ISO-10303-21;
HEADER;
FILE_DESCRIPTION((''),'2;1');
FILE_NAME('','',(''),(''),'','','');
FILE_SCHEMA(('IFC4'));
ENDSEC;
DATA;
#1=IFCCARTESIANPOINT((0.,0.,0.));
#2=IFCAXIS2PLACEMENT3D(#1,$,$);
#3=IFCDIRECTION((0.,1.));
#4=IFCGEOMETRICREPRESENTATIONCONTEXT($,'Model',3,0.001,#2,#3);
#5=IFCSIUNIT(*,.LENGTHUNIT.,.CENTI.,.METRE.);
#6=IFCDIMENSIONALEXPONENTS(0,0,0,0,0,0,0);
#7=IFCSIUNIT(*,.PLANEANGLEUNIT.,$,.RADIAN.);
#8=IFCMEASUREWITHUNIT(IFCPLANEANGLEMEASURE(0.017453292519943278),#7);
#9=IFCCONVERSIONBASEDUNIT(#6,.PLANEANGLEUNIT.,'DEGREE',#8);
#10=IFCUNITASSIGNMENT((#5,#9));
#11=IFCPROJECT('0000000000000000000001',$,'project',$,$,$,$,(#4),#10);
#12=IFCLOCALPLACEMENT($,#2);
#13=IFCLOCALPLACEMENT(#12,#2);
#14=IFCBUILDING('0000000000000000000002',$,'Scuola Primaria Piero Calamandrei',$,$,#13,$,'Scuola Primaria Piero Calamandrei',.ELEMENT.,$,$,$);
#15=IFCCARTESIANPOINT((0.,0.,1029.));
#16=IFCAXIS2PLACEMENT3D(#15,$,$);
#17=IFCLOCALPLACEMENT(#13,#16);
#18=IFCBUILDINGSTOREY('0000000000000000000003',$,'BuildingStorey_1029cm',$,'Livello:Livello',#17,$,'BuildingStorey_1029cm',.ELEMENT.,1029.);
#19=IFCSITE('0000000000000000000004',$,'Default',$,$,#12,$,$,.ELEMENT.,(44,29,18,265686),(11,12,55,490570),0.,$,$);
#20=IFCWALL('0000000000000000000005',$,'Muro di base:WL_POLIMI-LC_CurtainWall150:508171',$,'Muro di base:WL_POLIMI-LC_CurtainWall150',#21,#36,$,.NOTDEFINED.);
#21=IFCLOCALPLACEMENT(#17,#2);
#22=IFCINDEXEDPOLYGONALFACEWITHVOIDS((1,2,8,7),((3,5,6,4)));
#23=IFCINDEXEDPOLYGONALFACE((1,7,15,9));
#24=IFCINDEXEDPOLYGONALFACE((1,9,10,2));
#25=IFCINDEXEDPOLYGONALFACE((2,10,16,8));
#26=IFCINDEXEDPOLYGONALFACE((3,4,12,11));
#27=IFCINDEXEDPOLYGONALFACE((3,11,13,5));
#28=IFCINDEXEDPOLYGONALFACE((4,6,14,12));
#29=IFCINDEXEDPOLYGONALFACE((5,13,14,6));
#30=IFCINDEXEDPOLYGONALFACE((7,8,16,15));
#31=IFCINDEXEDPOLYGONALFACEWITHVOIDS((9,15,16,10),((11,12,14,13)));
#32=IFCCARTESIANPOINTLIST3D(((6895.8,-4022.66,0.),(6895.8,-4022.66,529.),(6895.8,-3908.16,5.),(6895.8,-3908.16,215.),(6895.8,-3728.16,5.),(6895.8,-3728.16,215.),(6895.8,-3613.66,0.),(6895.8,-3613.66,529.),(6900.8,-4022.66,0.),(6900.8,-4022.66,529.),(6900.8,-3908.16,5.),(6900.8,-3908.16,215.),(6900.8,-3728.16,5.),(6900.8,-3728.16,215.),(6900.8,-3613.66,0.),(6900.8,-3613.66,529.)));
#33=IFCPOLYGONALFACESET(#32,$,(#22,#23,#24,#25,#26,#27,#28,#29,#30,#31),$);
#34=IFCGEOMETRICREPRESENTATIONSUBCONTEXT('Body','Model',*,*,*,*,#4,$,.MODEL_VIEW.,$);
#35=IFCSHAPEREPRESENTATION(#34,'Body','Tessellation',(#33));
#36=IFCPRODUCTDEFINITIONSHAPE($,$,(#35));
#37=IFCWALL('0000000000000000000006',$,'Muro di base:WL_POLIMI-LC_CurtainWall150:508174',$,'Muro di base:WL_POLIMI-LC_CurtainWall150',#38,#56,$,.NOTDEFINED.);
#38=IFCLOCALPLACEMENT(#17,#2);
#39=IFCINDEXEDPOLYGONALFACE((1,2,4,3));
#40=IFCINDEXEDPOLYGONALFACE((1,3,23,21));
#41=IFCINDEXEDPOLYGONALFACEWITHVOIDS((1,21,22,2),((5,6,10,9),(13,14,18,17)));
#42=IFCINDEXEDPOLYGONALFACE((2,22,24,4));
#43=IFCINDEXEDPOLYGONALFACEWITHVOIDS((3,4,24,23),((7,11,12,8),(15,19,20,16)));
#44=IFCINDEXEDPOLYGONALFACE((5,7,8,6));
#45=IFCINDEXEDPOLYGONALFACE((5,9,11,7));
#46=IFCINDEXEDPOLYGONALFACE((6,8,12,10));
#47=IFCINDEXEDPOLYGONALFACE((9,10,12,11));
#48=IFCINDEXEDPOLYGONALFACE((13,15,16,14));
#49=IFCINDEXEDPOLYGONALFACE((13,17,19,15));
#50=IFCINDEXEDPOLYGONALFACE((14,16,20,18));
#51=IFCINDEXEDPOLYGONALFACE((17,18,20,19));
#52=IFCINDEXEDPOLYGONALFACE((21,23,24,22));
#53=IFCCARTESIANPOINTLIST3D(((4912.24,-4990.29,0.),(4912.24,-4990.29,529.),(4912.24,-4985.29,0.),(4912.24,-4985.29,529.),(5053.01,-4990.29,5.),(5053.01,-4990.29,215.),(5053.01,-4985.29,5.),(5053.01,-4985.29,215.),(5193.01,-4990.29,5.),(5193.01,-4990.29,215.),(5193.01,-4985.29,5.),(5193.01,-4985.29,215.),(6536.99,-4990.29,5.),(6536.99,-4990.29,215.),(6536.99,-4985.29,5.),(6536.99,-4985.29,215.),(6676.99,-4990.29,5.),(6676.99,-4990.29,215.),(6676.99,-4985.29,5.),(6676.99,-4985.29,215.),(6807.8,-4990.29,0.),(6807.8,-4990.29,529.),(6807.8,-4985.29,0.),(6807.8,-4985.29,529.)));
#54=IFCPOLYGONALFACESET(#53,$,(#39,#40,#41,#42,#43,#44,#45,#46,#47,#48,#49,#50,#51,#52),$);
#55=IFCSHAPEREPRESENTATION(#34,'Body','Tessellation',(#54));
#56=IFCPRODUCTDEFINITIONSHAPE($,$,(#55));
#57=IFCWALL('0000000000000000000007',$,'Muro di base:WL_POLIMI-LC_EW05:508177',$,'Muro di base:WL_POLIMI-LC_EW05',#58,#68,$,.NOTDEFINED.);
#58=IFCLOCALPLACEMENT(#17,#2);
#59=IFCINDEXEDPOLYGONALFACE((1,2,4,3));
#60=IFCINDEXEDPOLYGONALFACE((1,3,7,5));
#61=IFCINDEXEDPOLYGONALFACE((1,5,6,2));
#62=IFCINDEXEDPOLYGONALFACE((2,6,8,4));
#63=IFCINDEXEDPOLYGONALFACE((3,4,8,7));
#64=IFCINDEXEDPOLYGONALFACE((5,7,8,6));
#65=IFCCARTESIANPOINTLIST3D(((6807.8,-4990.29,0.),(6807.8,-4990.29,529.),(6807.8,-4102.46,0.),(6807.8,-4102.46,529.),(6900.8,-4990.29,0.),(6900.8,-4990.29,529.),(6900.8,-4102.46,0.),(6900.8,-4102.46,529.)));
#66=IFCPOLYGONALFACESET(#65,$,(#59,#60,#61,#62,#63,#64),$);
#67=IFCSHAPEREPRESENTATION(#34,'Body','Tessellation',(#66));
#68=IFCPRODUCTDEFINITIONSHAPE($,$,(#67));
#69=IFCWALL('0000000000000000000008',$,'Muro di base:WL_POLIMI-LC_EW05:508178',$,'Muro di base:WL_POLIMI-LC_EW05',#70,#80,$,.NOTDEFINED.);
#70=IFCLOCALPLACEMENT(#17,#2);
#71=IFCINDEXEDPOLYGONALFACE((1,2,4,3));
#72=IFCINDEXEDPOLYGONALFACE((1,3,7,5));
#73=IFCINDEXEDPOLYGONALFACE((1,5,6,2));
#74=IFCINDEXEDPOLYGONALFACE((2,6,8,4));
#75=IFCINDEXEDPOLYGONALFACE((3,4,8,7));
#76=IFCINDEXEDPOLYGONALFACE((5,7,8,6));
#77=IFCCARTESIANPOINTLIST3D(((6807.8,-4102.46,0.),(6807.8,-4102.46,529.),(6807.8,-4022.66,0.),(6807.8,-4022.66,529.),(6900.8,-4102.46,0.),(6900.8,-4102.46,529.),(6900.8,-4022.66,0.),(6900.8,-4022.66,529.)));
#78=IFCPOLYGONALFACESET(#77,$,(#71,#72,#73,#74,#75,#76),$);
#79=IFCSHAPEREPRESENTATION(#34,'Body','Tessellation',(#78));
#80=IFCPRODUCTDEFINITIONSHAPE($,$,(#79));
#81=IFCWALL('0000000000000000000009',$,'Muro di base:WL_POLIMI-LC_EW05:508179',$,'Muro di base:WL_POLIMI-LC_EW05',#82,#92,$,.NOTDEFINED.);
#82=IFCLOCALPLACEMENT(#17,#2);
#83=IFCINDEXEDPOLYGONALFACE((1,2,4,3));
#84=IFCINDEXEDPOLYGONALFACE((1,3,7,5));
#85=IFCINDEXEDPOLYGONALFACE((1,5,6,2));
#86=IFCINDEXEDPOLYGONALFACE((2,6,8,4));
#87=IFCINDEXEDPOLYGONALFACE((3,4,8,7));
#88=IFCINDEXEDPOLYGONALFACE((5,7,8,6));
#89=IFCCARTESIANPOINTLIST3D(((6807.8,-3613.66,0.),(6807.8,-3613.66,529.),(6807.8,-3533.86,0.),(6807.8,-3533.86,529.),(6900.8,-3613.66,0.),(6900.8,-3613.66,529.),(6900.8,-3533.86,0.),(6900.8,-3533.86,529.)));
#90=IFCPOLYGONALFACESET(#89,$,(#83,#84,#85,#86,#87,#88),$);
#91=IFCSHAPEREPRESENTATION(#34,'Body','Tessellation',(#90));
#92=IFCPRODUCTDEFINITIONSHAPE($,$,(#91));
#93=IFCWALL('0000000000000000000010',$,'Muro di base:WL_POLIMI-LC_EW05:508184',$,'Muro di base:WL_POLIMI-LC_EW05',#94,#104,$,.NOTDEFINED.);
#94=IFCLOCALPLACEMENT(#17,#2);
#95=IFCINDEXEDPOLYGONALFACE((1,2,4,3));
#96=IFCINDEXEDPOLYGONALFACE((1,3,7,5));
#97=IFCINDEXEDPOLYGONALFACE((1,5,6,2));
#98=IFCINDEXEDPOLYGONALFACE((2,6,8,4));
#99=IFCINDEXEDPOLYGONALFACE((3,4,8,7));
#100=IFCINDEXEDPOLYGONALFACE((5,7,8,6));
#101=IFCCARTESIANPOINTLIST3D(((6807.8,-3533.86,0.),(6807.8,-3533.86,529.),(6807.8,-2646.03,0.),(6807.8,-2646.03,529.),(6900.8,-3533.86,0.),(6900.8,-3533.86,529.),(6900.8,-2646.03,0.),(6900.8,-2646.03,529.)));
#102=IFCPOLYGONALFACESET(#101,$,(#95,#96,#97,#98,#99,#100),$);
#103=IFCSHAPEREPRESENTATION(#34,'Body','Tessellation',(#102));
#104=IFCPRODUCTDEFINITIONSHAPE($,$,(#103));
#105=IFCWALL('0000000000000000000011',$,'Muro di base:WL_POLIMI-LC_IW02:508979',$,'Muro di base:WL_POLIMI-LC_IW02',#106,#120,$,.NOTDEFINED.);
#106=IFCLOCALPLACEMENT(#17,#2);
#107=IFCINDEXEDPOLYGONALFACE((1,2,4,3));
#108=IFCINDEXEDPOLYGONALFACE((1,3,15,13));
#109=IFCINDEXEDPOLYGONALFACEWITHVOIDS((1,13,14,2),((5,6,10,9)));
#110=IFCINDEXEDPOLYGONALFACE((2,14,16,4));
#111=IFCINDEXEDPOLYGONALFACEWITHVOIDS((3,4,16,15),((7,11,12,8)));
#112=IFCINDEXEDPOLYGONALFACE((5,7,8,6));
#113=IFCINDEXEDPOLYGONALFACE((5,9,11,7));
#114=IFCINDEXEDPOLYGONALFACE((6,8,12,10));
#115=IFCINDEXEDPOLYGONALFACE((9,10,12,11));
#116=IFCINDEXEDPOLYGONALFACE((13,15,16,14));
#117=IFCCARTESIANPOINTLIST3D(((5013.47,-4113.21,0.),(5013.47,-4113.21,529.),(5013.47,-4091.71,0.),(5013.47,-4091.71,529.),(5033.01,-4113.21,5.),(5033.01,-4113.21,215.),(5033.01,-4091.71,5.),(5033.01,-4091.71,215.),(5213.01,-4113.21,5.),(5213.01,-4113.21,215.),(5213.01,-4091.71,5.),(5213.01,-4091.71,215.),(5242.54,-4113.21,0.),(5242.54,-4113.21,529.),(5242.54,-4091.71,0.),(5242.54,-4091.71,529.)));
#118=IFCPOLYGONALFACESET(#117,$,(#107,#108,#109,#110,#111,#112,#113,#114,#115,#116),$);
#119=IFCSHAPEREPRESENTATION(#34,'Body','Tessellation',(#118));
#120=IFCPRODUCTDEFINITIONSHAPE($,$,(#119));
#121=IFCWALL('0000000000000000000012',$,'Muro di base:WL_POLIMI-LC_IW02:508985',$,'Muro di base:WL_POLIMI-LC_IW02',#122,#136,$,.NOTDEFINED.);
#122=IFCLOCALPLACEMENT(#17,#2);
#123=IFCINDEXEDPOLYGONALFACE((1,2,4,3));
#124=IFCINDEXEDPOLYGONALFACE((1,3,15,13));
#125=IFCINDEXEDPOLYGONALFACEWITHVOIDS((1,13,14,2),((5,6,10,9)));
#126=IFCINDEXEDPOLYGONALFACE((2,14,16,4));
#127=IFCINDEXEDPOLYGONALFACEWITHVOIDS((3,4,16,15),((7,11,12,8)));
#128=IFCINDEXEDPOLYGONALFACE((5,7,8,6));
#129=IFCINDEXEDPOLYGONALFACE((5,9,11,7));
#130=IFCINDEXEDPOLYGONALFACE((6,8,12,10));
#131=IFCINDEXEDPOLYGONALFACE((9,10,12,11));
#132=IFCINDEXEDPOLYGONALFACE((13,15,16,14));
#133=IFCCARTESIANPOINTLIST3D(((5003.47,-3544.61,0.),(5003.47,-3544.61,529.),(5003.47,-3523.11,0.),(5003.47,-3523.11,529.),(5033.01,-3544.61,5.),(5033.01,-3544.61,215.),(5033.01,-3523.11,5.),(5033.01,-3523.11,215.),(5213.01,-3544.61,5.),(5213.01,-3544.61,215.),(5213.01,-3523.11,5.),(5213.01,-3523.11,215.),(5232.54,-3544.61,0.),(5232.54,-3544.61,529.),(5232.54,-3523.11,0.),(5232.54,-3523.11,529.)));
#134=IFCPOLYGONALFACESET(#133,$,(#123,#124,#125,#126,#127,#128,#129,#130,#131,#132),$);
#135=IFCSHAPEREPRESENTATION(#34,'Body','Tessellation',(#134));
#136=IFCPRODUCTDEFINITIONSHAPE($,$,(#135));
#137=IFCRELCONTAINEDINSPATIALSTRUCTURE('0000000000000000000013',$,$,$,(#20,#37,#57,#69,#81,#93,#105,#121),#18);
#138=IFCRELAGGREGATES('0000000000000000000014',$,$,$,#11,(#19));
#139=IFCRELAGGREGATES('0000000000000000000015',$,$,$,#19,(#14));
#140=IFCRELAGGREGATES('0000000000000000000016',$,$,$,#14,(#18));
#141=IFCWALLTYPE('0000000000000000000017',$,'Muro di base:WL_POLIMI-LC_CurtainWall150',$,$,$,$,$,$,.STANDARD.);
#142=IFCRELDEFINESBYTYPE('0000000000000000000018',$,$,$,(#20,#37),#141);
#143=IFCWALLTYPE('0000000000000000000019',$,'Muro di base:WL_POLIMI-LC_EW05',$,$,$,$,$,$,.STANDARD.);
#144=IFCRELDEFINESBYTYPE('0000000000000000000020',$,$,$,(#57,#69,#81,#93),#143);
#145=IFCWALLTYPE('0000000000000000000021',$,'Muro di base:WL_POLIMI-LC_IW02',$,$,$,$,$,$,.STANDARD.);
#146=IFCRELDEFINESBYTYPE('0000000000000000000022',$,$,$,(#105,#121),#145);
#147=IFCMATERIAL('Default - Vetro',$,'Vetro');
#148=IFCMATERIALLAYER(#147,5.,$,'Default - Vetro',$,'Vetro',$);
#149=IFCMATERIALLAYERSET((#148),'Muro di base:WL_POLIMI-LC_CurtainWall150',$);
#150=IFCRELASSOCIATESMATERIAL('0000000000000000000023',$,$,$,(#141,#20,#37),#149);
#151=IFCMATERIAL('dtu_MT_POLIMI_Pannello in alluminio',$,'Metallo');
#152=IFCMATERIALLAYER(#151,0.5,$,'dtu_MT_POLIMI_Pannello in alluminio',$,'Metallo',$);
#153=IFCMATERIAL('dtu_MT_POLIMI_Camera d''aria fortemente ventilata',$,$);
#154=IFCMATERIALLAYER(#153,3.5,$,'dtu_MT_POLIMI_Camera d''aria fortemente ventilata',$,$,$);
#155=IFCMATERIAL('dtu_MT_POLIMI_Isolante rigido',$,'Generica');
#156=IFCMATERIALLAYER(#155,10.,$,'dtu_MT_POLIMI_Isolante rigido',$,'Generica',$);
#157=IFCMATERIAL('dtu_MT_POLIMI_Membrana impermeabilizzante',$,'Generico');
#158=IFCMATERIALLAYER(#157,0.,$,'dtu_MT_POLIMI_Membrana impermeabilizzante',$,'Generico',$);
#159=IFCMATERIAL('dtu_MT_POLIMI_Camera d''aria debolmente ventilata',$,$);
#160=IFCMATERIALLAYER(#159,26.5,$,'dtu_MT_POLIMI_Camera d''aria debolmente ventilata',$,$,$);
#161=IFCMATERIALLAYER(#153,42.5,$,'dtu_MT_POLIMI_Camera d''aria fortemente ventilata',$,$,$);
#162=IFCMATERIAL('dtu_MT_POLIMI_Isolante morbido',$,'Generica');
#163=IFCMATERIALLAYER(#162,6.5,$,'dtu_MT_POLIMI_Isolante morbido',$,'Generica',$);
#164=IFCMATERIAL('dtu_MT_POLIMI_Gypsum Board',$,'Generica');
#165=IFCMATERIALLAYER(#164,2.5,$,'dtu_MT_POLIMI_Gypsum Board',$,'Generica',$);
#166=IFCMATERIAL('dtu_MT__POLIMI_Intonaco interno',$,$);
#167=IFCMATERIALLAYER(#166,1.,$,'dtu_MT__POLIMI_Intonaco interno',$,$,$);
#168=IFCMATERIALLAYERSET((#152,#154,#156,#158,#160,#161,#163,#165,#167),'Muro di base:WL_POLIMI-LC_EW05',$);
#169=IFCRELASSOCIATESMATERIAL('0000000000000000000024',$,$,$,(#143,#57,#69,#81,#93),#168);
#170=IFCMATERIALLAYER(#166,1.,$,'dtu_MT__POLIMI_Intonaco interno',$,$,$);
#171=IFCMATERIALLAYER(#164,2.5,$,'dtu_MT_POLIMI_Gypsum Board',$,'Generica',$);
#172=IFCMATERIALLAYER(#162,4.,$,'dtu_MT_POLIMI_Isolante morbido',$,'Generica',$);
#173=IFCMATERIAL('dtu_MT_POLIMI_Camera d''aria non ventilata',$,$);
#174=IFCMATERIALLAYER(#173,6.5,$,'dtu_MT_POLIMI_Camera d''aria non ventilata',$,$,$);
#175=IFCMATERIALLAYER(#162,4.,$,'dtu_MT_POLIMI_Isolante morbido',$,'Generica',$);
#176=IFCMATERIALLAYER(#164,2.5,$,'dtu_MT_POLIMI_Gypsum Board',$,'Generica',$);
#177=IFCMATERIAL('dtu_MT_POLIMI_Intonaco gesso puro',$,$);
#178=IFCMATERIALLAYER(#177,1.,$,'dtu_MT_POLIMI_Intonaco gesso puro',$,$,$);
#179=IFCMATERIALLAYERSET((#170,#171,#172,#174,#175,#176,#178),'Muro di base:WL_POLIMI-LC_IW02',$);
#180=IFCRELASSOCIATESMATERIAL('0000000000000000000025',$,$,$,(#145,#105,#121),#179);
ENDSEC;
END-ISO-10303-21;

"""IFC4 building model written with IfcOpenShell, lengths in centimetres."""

from ifc_helpers import new_model, entity, si_unit, converted_unit, direction, frame, frame_2d, origin, place, context, subcontext, project, spatial, rectangle, extrude, material, layer, layer_set, layer_usage, type_object, element, save


model = new_model("IFC4")

# Units and contexts
model_context = context("Model", 3, precision=0.001, world=origin(), true_north=direction((0.0, 1.0)))
body_context = subcontext(model_context, "Body", "Model", "MODEL_VIEW")
ifc_project = project(units=[si_unit("LENGTHUNIT", "METRE", prefix="CENTI"), converted_unit("PLANEANGLEUNIT", "DEGREE", entity("IfcPlaneAngleMeasure", 0.017453292519943278), si_unit("PLANEANGLEUNIT", "RADIAN"), dimensions=[0, 0, 0, 0, 0, 0, 0])], contexts=[model_context])

# Site, building, storey
site_placement = place(None, origin())
site = spatial("IfcSite", under=ifc_project, at=site_placement, Name="Default", CompositionType="ELEMENT", RefLatitude=(44, 29, 18, 265686), RefLongitude=(11, 12, 55, 490570), RefElevation=0.0)
building_placement = place(site_placement, origin())
building = spatial("IfcBuilding", under=site, at=building_placement, Name="Scuola Primaria Piero Calamandrei", LongName="Scuola Primaria Piero Calamandrei", CompositionType="ELEMENT")
storey_placement = place(building_placement, frame((0.0, 0.0, 1029.0)))
storey = spatial("IfcBuildingStorey", under=building, at=storey_placement, Name="BuildingStorey_1029cm", ObjectType="Livello:Livello", LongName="BuildingStorey_1029cm", CompositionType="ELEMENT", Elevation=1029.0)

# Wall, opening
ifc_material_1 = material(Name="Default - Vetro", Category="Vetro")
ifc_layer_1 = layer(ifc_material_1, 5.0, Name="Default - Vetro", Category="Vetro")
ifc_layer_set_1 = layer_set([ifc_layer_1], Name="Muro di base:WL_POLIMI-LC_CurtainWall150")
ifc_layer_usage_1 = layer_usage(ifc_layer_set_1, "AXIS2", "NEGATIVE", 2.5)
wall_type_1 = type_object("IfcWallType", Name="Muro di base:WL_POLIMI-LC_CurtainWall150", PredefinedType="STANDARD", material=ifc_layer_set_1)
wall_1_placement = place(storey_placement, frame((6898.3, -3613.66, 0.0), z_axis=(0.0, 0.0, 1.0), x_axis=(0.0, -1.0, 0.0)))
wall_1 = element("IfcWall", 1, at=wall_1_placement, inside=storey, type_object=wall_type_1, material=ifc_layer_usage_1, Name="Muro di base:WL_POLIMI-LC_CurtainWall150:508171", ObjectType="Muro di base:WL_POLIMI-LC_CurtainWall150", PredefinedType="NOTDEFINED", context=body_context, shape_type="SweptSolid", body=[
    extrude(rectangle(XDim=409.0, YDim=5.0, at=frame_2d((204.5, 0.0), x_axis=(-1.0, 0.0))), origin(), (0.0, 0.0, 1.0), 529.0),
])
opening_1_placement = place(wall_1_placement, frame((114.5, -2.5, 5.0)))
element("IfcOpeningElement", 2, at=opening_1_placement, cuts=wall_1, PredefinedType="OPENING", context=body_context, shape_type="SweptSolid", body=[
    extrude(rectangle(XDim=210.0, YDim=180.0, at=frame_2d((105.0, 90.0), x_axis=(-1.0, 0.0))), frame((0.0, 0.0, 0.0), z_axis=(0.0, 1.0, 0.0), x_axis=(0.0, 0.0, 1.0)), (0.0, 0.0, 1.0), 5.0),
])

# Wall, openings
ifc_layer_usage_2 = layer_usage(ifc_layer_set_1, "AXIS2", "NEGATIVE", 2.5)
wall_2_placement = place(storey_placement, frame((6807.8, -4987.79, 0.0), z_axis=(0.0, 0.0, 1.0), x_axis=(-1.0, 0.0, 0.0)))
wall_2 = element("IfcWall", 3, at=wall_2_placement, inside=storey, type_object=wall_type_1, material=ifc_layer_usage_2, Name="Muro di base:WL_POLIMI-LC_CurtainWall150:508174", ObjectType="Muro di base:WL_POLIMI-LC_CurtainWall150", PredefinedType="NOTDEFINED", context=body_context, shape_type="SweptSolid", body=[
    extrude(rectangle(XDim=1895.56, YDim=5.0, at=frame_2d((947.78, 0.0), x_axis=(-1.0, 0.0))), origin(), (0.0, 0.0, 1.0), 529.0),
])
opening_2_placement = place(wall_2_placement, frame((1614.79, -2.5, 5.0)))
element("IfcOpeningElement", 4, at=opening_2_placement, cuts=wall_2, PredefinedType="OPENING", context=body_context, shape_type="SweptSolid", body=[
    extrude(rectangle(XDim=210.0, YDim=140.0, at=frame_2d((105.0, 70.0), x_axis=(-1.0, 0.0))), frame((0.0, 0.0, 0.0), z_axis=(0.0, 1.0, 0.0), x_axis=(0.0, 0.0, 1.0)), (0.0, 0.0, 1.0), 5.0),
])
opening_3_placement = place(wall_2_placement, frame((130.81, -2.5, 5.0)))
element("IfcOpeningElement", 5, at=opening_3_placement, cuts=wall_2, PredefinedType="OPENING", context=body_context, shape_type="SweptSolid", body=[
    extrude(rectangle(XDim=210.0, YDim=140.0, at=frame_2d((105.0, 70.0), x_axis=(-1.0, 0.0))), frame((0.0, 0.0, 0.0), z_axis=(0.0, 1.0, 0.0), x_axis=(0.0, 0.0, 1.0)), (0.0, 0.0, 1.0), 5.0),
])

# Walls
ifc_material_2 = material(Name="dtu_MT_POLIMI_Pannello in alluminio", Category="Metallo")
ifc_layer_2 = layer(ifc_material_2, 0.5, Name="dtu_MT_POLIMI_Pannello in alluminio", Category="Metallo")
ifc_material_3 = material(Name="dtu_MT_POLIMI_Camera d'aria fortemente ventilata")
ifc_layer_3 = layer(ifc_material_3, 3.5, Name="dtu_MT_POLIMI_Camera d'aria fortemente ventilata")
ifc_material_4 = material(Name="dtu_MT_POLIMI_Isolante rigido", Category="Generica")
ifc_layer_4 = layer(ifc_material_4, 10.0, Name="dtu_MT_POLIMI_Isolante rigido", Category="Generica")
ifc_material_5 = material(Name="dtu_MT_POLIMI_Membrana impermeabilizzante", Category="Generico")
ifc_layer_5 = layer(ifc_material_5, 0.0, Name="dtu_MT_POLIMI_Membrana impermeabilizzante", Category="Generico")
ifc_material_6 = material(Name="dtu_MT_POLIMI_Camera d'aria debolmente ventilata")
ifc_layer_6 = layer(ifc_material_6, 26.5, Name="dtu_MT_POLIMI_Camera d'aria debolmente ventilata")
ifc_layer_7 = layer(ifc_material_3, 42.5, Name="dtu_MT_POLIMI_Camera d'aria fortemente ventilata")
ifc_material_7 = material(Name="dtu_MT_POLIMI_Isolante morbido", Category="Generica")
ifc_layer_8 = layer(ifc_material_7, 6.5, Name="dtu_MT_POLIMI_Isolante morbido", Category="Generica")
ifc_material_8 = material(Name="dtu_MT_POLIMI_Gypsum Board", Category="Generica")
ifc_layer_9 = layer(ifc_material_8, 2.5, Name="dtu_MT_POLIMI_Gypsum Board", Category="Generica")
ifc_material_9 = material(Name="dtu_MT__POLIMI_Intonaco interno")
ifc_layer_10 = layer(ifc_material_9, 1.0, Name="dtu_MT__POLIMI_Intonaco interno")
ifc_layer_set_2 = layer_set([ifc_layer_2, ifc_layer_3, ifc_layer_4, ifc_layer_5, ifc_layer_6, ifc_layer_7, ifc_layer_8, ifc_layer_9, ifc_layer_10], Name="Muro di base:WL_POLIMI-LC_EW05")
ifc_layer_usage_3 = layer_usage(ifc_layer_set_2, "AXIS2", "NEGATIVE", 46.5)
wall_type_2 = type_object("IfcWallType", Name="Muro di base:WL_POLIMI-LC_EW05", PredefinedType="STANDARD", material=ifc_layer_set_2)
wall_3_placement = place(storey_placement, frame((6854.3, -4102.46, 0.0), z_axis=(0.0, 0.0, 1.0), x_axis=(0.0, -1.0, 0.0)))
element("IfcWall", 6, at=wall_3_placement, inside=storey, type_object=wall_type_2, material=ifc_layer_usage_3, Name="Muro di base:WL_POLIMI-LC_EW05:508177", ObjectType="Muro di base:WL_POLIMI-LC_EW05", PredefinedType="NOTDEFINED", context=body_context, shape_type="SweptSolid", body=[
    extrude(rectangle(XDim=887.82, YDim=93.0, at=frame_2d((443.91, 0.0), x_axis=(-1.0, 0.0))), origin(), (0.0, 0.0, 1.0), 529.0),
])
ifc_layer_usage_4 = layer_usage(ifc_layer_set_2, "AXIS2", "NEGATIVE", 46.5)
wall_4_placement = place(storey_placement, frame((6854.3, -4022.66, 0.0), z_axis=(0.0, 0.0, 1.0), x_axis=(0.0, -1.0, 0.0)))
element("IfcWall", 7, at=wall_4_placement, inside=storey, type_object=wall_type_2, material=ifc_layer_usage_4, Name="Muro di base:WL_POLIMI-LC_EW05:508178", ObjectType="Muro di base:WL_POLIMI-LC_EW05", PredefinedType="NOTDEFINED", context=body_context, shape_type="SweptSolid", body=[
    extrude(rectangle(XDim=79.8, YDim=93.0, at=frame_2d((39.9, 0.0), x_axis=(-1.0, 0.0))), origin(), (0.0, 0.0, 1.0), 529.0),
])
ifc_layer_usage_5 = layer_usage(ifc_layer_set_2, "AXIS2", "NEGATIVE", 46.5)
wall_5_placement = place(storey_placement, frame((6854.3, -3533.86, 0.0), z_axis=(0.0, 0.0, 1.0), x_axis=(0.0, -1.0, 0.0)))
element("IfcWall", 8, at=wall_5_placement, inside=storey, type_object=wall_type_2, material=ifc_layer_usage_5, Name="Muro di base:WL_POLIMI-LC_EW05:508179", ObjectType="Muro di base:WL_POLIMI-LC_EW05", PredefinedType="NOTDEFINED", context=body_context, shape_type="SweptSolid", body=[
    extrude(rectangle(XDim=79.8, YDim=93.0, at=frame_2d((39.9, 0.0), x_axis=(-1.0, 0.0))), origin(), (0.0, 0.0, 1.0), 529.0),
])
ifc_layer_usage_6 = layer_usage(ifc_layer_set_2, "AXIS2", "NEGATIVE", 46.5)
wall_6_placement = place(storey_placement, frame((6854.3, -2646.03, 0.0), z_axis=(0.0, 0.0, 1.0), x_axis=(0.0, -1.0, 0.0)))
element("IfcWall", 9, at=wall_6_placement, inside=storey, type_object=wall_type_2, material=ifc_layer_usage_6, Name="Muro di base:WL_POLIMI-LC_EW05:508184", ObjectType="Muro di base:WL_POLIMI-LC_EW05", PredefinedType="NOTDEFINED", context=body_context, shape_type="SweptSolid", body=[
    extrude(rectangle(XDim=887.82, YDim=93.0, at=frame_2d((443.91, 0.0), x_axis=(-1.0, 0.0))), origin(), (0.0, 0.0, 1.0), 529.0),
])

# Walls, openings
ifc_layer_11 = layer(ifc_material_9, 1.0, Name="dtu_MT__POLIMI_Intonaco interno")
ifc_layer_12 = layer(ifc_material_8, 2.5, Name="dtu_MT_POLIMI_Gypsum Board", Category="Generica")
ifc_layer_13 = layer(ifc_material_7, 4.0, Name="dtu_MT_POLIMI_Isolante morbido", Category="Generica")
ifc_material_10 = material(Name="dtu_MT_POLIMI_Camera d'aria non ventilata")
ifc_layer_14 = layer(ifc_material_10, 6.5, Name="dtu_MT_POLIMI_Camera d'aria non ventilata")
ifc_layer_15 = layer(ifc_material_7, 4.0, Name="dtu_MT_POLIMI_Isolante morbido", Category="Generica")
ifc_layer_16 = layer(ifc_material_8, 2.5, Name="dtu_MT_POLIMI_Gypsum Board", Category="Generica")
ifc_material_11 = material(Name="dtu_MT_POLIMI_Intonaco gesso puro")
ifc_layer_17 = layer(ifc_material_11, 1.0, Name="dtu_MT_POLIMI_Intonaco gesso puro")
ifc_layer_set_3 = layer_set([ifc_layer_11, ifc_layer_12, ifc_layer_13, ifc_layer_14, ifc_layer_15, ifc_layer_16, ifc_layer_17], Name="Muro di base:WL_POLIMI-LC_IW02")
ifc_layer_usage_7 = layer_usage(ifc_layer_set_3, "AXIS2", "NEGATIVE", 10.75)
wall_type_3 = type_object("IfcWallType", Name="Muro di base:WL_POLIMI-LC_IW02", PredefinedType="STANDARD", material=ifc_layer_set_3)
wall_7_placement = place(storey_placement, frame((5242.54, -4102.46, 0.0), z_axis=(0.0, 0.0, 1.0), x_axis=(-1.0, 0.0, 0.0)))
wall_7 = element("IfcWall", 10, at=wall_7_placement, inside=storey, type_object=wall_type_3, material=ifc_layer_usage_7, Name="Muro di base:WL_POLIMI-LC_IW02:508979", ObjectType="Muro di base:WL_POLIMI-LC_IW02", PredefinedType="NOTDEFINED", context=body_context, shape_type="SweptSolid", body=[
    extrude(rectangle(XDim=229.07, YDim=21.5, at=frame_2d((114.54, 0.0), x_axis=(-1.0, 0.0))), origin(), (0.0, 0.0, 1.0), 529.0),
])
opening_4_placement = place(wall_7_placement, frame((209.54, 10.75, 5.0)))
element("IfcOpeningElement", 11, at=opening_4_placement, cuts=wall_7, PredefinedType="OPENING", context=body_context, shape_type="SweptSolid", body=[
    extrude(rectangle(XDim=210.0, YDim=180.0, at=frame_2d((105.0, 90.0), x_axis=(-1.0, 0.0))), frame((0.0, 0.0, 0.0), z_axis=(0.0, -1.0, 0.0), x_axis=(0.0, 0.0, 1.0)), (0.0, 0.0, 1.0), 21.5),
])
ifc_layer_usage_8 = layer_usage(ifc_layer_set_3, "AXIS2", "NEGATIVE", 10.75)
wall_8_placement = place(storey_placement, frame((5003.47, -3533.86, 0.0)))
wall_8 = element("IfcWall", 12, at=wall_8_placement, inside=storey, type_object=wall_type_3, material=ifc_layer_usage_8, Name="Muro di base:WL_POLIMI-LC_IW02:508985", ObjectType="Muro di base:WL_POLIMI-LC_IW02", PredefinedType="NOTDEFINED", context=body_context, shape_type="SweptSolid", body=[
    extrude(rectangle(XDim=229.07, YDim=21.5, at=frame_2d((114.54, 0.0), x_axis=(-1.0, 0.0))), origin(), (0.0, 0.0, 1.0), 529.0),
])
opening_5_placement = place(wall_8_placement, frame((209.54, 10.75, 5.0)))
element("IfcOpeningElement", 13, at=opening_5_placement, cuts=wall_8, PredefinedType="OPENING", context=body_context, shape_type="SweptSolid", body=[
    extrude(rectangle(XDim=210.0, YDim=180.0, at=frame_2d((105.0, 90.0), x_axis=(-1.0, 0.0))), frame((0.0, 0.0, 0.0), z_axis=(0.0, -1.0, 0.0), x_axis=(0.0, 0.0, 1.0)), (0.0, 0.0, 1.0), 21.5),
])

save(model, "model.ifc")
